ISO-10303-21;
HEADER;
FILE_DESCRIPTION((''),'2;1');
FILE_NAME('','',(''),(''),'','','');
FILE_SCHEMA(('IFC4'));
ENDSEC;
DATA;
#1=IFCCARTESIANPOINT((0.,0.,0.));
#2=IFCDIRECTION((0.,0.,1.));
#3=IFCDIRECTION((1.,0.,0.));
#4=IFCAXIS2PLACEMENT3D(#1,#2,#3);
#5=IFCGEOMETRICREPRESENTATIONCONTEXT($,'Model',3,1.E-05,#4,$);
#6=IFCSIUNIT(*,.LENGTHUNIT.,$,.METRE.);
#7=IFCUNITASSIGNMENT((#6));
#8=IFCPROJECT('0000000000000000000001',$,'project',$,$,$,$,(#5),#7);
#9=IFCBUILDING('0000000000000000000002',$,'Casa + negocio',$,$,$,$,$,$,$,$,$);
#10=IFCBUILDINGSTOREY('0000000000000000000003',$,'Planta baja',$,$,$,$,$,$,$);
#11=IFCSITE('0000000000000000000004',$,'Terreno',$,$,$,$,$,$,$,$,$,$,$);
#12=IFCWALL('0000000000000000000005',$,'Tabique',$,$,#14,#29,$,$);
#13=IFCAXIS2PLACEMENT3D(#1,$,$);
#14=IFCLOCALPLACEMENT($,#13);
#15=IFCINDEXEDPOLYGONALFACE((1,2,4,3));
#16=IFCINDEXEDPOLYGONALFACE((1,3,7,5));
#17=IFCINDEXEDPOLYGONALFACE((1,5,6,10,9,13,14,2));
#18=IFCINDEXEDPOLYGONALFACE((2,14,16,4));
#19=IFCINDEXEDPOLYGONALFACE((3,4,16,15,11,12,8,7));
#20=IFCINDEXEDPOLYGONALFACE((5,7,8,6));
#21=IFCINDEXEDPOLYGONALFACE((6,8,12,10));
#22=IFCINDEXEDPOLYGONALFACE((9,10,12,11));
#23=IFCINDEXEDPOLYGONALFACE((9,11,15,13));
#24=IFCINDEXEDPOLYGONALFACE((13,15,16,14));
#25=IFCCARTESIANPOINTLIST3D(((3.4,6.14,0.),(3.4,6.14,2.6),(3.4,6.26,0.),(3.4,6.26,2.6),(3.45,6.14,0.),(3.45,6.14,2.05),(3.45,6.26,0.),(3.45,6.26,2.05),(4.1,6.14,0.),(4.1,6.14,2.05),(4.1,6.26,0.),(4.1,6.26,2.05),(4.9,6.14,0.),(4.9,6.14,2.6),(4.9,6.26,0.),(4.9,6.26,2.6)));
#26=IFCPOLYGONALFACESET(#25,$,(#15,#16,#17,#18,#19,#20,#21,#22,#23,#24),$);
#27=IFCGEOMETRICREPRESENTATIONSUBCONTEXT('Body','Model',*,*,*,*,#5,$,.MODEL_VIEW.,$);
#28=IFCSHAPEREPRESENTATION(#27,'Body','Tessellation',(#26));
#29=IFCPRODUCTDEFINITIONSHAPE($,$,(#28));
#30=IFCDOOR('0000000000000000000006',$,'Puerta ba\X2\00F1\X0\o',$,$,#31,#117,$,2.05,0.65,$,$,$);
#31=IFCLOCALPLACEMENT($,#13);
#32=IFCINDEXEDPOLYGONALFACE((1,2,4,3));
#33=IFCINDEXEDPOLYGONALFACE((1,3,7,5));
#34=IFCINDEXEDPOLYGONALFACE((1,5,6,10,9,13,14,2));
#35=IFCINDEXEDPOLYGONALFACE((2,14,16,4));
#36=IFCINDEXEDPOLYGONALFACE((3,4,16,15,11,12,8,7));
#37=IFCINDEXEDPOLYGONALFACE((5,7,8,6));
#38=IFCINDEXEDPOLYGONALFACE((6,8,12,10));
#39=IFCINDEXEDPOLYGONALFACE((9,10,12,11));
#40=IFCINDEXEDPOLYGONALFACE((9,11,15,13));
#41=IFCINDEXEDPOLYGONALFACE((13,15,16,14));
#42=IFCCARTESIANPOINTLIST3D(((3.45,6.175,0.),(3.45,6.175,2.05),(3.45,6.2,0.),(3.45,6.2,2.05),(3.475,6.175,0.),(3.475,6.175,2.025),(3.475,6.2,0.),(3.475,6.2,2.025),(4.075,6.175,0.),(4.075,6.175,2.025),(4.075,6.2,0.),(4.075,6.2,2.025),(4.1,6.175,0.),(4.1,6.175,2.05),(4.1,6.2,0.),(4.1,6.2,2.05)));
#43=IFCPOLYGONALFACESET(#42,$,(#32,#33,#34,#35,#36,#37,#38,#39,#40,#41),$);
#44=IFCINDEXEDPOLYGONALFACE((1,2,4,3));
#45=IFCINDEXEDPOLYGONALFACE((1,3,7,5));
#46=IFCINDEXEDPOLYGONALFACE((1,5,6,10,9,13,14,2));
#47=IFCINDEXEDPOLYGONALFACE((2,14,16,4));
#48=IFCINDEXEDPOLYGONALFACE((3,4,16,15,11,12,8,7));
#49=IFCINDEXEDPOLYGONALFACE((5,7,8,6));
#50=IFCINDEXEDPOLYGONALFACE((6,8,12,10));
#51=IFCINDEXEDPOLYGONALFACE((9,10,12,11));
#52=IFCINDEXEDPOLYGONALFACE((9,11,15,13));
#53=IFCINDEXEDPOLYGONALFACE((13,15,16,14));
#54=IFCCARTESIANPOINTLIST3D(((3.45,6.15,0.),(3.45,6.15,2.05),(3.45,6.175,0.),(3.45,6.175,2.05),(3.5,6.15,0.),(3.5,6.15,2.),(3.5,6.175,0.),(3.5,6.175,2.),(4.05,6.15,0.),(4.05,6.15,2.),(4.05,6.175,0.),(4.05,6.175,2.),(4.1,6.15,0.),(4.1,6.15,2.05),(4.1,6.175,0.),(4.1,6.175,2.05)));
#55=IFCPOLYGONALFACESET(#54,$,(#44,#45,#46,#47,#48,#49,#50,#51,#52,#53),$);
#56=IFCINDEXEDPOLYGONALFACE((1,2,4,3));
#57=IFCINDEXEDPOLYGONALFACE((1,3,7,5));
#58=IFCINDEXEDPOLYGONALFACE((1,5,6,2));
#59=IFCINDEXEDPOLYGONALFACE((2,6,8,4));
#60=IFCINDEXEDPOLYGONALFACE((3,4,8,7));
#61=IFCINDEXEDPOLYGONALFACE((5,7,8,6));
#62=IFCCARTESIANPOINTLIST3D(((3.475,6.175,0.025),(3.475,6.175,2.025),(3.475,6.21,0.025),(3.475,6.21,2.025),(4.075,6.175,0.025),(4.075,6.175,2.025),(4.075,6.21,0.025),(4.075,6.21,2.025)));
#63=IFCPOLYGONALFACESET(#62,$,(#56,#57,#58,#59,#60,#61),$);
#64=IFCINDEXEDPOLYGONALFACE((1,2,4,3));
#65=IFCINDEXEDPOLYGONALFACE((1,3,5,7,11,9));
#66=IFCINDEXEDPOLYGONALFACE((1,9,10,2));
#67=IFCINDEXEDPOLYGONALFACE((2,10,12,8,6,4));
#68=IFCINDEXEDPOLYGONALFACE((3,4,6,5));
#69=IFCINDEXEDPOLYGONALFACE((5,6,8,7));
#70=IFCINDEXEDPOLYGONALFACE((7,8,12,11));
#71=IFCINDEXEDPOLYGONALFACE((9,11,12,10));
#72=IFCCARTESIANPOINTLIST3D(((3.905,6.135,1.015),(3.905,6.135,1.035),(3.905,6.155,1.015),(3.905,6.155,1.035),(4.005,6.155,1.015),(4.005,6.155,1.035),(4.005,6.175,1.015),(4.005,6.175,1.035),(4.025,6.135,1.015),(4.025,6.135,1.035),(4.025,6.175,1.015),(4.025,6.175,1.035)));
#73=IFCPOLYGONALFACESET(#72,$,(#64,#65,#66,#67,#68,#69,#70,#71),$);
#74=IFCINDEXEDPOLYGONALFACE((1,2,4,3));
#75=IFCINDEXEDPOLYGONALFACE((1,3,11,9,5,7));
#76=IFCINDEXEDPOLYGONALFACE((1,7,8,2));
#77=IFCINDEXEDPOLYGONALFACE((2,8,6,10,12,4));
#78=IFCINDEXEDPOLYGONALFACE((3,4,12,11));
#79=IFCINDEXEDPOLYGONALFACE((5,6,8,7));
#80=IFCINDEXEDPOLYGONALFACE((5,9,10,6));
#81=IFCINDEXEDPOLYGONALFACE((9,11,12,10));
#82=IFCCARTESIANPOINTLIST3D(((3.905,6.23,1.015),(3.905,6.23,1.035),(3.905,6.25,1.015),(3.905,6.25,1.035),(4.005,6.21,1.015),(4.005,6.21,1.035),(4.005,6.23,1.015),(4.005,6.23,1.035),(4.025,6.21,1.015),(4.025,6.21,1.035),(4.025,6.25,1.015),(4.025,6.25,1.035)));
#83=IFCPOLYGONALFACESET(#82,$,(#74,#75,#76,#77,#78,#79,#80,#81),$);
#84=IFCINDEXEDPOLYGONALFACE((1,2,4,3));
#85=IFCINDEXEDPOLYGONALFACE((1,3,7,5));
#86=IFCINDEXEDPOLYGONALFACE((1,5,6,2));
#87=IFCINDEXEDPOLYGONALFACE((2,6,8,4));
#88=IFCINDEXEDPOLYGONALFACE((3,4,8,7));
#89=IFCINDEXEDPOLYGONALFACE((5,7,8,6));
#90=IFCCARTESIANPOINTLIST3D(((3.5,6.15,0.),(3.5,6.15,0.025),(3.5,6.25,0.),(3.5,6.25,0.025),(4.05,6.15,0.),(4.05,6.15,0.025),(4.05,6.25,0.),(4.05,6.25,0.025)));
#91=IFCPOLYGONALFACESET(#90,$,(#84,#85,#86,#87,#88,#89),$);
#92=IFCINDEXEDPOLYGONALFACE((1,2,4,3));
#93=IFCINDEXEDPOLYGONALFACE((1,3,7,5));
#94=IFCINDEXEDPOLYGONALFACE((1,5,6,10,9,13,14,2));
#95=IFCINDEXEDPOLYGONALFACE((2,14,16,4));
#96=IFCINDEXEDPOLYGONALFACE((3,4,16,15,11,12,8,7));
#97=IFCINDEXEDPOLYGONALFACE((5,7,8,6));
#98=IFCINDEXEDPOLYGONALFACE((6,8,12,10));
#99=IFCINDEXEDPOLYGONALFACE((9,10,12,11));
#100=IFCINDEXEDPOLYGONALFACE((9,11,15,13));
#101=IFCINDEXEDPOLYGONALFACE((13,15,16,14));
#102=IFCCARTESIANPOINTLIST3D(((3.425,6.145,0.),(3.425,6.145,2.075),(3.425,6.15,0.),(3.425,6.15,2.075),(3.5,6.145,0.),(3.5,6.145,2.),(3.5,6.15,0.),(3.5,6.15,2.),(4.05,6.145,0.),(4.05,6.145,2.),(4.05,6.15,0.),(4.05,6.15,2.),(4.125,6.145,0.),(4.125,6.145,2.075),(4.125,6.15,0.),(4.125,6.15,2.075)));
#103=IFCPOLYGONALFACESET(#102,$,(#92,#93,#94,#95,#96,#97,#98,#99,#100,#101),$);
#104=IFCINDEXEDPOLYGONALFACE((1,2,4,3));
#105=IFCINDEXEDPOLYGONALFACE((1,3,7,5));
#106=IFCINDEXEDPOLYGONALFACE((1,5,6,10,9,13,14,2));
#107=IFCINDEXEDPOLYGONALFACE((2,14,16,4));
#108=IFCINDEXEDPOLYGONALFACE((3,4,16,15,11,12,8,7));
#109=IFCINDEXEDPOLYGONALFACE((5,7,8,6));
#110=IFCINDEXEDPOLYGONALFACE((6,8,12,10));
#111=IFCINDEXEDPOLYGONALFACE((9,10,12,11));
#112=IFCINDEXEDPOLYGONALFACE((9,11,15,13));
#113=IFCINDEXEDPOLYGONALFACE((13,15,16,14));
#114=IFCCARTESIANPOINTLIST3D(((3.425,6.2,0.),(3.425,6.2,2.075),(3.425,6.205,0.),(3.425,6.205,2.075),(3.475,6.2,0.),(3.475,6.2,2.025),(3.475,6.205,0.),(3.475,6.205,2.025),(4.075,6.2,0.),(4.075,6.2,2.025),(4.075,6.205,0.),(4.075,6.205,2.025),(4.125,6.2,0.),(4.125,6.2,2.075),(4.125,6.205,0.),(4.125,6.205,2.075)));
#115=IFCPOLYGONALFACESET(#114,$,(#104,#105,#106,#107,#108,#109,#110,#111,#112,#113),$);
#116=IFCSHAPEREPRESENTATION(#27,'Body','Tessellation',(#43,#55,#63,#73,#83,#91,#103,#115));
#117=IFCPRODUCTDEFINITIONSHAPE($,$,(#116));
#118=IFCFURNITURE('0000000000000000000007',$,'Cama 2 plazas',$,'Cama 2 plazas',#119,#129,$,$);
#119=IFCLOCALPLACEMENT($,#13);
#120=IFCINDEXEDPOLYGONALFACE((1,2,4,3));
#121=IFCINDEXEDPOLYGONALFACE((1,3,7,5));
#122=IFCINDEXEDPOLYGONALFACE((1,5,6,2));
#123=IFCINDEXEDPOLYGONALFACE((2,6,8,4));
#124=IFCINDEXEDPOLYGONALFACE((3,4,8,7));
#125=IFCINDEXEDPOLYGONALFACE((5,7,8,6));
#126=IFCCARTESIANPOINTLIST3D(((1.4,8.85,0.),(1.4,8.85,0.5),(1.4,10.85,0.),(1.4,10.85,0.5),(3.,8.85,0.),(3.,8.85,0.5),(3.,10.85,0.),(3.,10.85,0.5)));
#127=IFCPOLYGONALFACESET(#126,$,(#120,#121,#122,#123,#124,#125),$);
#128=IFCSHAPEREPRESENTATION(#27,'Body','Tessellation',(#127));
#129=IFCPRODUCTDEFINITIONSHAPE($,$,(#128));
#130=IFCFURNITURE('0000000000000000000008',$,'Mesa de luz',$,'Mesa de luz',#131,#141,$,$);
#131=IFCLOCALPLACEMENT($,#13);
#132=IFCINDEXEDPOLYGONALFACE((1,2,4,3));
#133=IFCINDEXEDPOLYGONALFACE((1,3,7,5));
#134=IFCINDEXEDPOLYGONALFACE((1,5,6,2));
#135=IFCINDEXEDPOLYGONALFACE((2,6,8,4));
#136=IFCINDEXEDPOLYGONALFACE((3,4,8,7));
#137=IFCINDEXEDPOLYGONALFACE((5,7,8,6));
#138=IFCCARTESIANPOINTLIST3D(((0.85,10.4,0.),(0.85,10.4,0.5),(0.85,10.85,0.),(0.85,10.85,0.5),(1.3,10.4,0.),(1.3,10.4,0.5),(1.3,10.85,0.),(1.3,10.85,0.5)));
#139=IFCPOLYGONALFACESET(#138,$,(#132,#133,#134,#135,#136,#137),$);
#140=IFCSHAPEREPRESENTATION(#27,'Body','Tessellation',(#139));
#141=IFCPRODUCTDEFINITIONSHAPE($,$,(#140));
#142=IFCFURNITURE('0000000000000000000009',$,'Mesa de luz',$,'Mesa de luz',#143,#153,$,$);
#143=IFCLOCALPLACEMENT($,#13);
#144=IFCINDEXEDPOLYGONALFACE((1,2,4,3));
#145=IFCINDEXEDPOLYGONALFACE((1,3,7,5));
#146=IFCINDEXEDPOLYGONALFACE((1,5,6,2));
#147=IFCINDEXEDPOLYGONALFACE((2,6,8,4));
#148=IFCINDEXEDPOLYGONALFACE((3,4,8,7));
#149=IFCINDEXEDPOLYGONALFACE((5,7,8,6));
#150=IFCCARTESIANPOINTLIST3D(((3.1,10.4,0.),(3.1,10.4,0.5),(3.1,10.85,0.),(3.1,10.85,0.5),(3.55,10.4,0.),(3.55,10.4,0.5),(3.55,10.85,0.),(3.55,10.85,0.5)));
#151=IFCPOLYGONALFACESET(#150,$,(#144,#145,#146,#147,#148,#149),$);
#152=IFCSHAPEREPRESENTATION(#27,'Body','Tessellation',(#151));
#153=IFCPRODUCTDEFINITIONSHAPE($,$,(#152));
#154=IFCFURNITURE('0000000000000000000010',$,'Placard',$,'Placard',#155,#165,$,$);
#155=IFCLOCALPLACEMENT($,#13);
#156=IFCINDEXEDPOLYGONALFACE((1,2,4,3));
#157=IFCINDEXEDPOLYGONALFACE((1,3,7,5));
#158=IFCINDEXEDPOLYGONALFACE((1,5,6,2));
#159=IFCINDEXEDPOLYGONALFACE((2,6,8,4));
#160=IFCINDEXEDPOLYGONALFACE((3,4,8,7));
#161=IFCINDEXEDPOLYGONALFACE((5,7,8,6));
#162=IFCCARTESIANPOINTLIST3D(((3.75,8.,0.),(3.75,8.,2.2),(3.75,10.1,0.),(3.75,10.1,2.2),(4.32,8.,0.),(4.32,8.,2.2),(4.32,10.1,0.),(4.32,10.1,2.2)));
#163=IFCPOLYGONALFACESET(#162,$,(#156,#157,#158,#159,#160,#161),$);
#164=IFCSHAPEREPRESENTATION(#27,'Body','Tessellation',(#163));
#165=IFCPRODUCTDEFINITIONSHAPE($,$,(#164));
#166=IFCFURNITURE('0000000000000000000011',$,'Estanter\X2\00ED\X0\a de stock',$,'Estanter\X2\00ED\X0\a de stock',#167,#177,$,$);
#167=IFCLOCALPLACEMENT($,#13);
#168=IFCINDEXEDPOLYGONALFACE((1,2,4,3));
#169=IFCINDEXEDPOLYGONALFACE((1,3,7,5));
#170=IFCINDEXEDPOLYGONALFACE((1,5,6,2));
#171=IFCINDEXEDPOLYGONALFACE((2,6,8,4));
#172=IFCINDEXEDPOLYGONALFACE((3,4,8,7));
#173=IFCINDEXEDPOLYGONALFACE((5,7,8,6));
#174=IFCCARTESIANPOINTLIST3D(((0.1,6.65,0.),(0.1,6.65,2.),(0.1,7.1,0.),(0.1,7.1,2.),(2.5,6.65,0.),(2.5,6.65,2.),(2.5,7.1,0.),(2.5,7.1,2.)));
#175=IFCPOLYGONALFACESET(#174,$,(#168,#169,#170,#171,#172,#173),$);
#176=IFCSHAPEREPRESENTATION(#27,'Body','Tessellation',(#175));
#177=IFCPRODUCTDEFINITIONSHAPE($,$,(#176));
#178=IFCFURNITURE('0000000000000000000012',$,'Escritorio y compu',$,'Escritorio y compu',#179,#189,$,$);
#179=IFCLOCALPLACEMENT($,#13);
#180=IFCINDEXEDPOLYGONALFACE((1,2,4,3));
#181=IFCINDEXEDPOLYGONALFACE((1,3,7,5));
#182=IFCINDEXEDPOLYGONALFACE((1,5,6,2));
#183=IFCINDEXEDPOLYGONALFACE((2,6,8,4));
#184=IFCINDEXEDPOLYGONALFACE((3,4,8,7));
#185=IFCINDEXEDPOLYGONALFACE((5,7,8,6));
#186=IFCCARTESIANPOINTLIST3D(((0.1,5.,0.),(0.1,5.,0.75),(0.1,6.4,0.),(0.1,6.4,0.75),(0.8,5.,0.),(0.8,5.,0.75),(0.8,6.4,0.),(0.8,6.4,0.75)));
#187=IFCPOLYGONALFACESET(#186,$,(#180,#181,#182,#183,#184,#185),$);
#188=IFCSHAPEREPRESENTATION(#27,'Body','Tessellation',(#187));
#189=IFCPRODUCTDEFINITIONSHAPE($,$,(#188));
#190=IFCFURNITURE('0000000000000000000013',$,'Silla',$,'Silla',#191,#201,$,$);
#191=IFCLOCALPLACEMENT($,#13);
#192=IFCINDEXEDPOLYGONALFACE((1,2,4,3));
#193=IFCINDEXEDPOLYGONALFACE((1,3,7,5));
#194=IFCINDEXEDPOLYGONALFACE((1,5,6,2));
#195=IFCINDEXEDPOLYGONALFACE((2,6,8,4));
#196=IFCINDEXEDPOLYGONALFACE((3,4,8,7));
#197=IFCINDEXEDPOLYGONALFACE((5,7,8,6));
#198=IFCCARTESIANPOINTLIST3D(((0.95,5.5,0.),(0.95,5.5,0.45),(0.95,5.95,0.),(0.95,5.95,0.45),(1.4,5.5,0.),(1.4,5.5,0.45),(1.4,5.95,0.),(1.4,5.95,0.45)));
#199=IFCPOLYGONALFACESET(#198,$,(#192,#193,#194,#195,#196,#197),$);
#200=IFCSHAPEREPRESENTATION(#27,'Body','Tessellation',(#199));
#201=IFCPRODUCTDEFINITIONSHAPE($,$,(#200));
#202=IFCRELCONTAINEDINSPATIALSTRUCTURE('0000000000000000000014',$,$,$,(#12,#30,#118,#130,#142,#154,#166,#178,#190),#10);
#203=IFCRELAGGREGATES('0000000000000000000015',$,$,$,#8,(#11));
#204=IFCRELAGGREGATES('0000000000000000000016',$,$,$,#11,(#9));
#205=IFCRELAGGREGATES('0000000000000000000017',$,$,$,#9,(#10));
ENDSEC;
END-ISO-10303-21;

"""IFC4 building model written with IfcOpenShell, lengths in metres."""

from ifc_helpers import new_model, si_unit, frame, origin_with_axes, place, context, subcontext, project, spatial, line, indexed_curve, outline, extrude, element, fill, save


model = new_model("IFC4")

# Units and contexts
model_context = context("Model", 3, precision=1e-05, world=origin_with_axes())
body_context = subcontext(model_context, "Body", "Model", "MODEL_VIEW")
ifc_project = project(units=[si_unit("LENGTHUNIT", "METRE")], contexts=[model_context])

# Site, building, storey
site = spatial("IfcSite", under=ifc_project, Name="Terreno")
building = spatial("IfcBuilding", under=site, Name="Casa + negocio")
storey = spatial("IfcBuildingStorey", under=building, Name="Planta baja")

# Wall, opening, door
wall_1_placement = place(None, frame((3.4, 6.2, 0.0), z_axis=(0.0, 0.0, 1.0), x_axis=(1.0, 0.0, 0.0)))
wall_1 = element("IfcWall", 1, at=wall_1_placement, inside=storey, Name="Tabique", context=body_context, shape_type="SweptSolid", body=[
    extrude(outline(indexed_curve([(0.0, 0.0), (0.0, 0.12), (1.5, 0.12), (1.5, 0.0), (0.0, 0.0)], self_intersect=False)), frame((0.0, -0.06, 0.0), z_axis=(0.0, 0.0, 1.0), x_axis=(1.0, 0.0, 0.0)), (0.0, 0.0, 1.0), 2.6),
])
opening_1_placement = place(wall_1_placement, frame((0.05, 0.0, 0.0), z_axis=(0.0, 0.0, 1.0), x_axis=(1.0, 0.0, 0.0)))
opening_1 = element("IfcOpeningElement", 2, at=opening_1_placement, cuts=wall_1, context=body_context, shape_type="SweptSolid", body=[
    extrude(outline(indexed_curve([(0.0, 0.0), (0.0, 0.22), (0.65, 0.22), (0.65, 0.0), (0.0, 0.0)], self_intersect=False)), frame((0.0, -0.11, 0.0), z_axis=(0.0, 0.0, 1.0), x_axis=(1.0, 0.0, 0.0)), (0.0, 0.0, 1.0), 2.05),
])
door_1_placement = place(opening_1_placement, frame((0.0, -0.05, 0.0), z_axis=(0.0, 0.0, 1.0), x_axis=(1.0, 0.0, 0.0)))
door_1 = element("IfcDoor", 3, at=door_1_placement, inside=storey, Name="Puerta baño", OverallHeight=2.05, OverallWidth=0.65, context=body_context, shape_type="SweptSolid", body=[
    extrude(outline(indexed_curve([(0.0, 0.0), (0.0, 2.05), (0.65, 2.05), (0.65, 0.0), (0.625, 0.0), (0.625, 2.025), (0.025, 2.025), (0.025, 0.0)], segments=[line(1, 2, 3, 4, 5, 6, 7, 8, 1)])), frame((0.0, 0.025, 0.0), z_axis=(0.0, -1.0, 0.0), x_axis=(1.0, 0.0, 0.0)), (0.0, 0.0, -1.0), 0.025),
    extrude(outline(indexed_curve([(0.0, 0.0), (0.0, 2.05), (0.65, 2.05), (0.65, 0.0), (0.6, 0.0), (0.6, 2.0), (0.05, 2.0), (0.05, 0.0)], segments=[line(1, 2, 3, 4, 5, 6, 7, 8, 1)])), frame((0.0, 0.0, 0.0), z_axis=(0.0, -1.0, 0.0), x_axis=(1.0, 0.0, 0.0)), (0.0, 0.0, -1.0), 0.025),
    extrude(outline(indexed_curve([(0.0, 0.0), (0.6, 0.0), (0.6, 0.035), (0.0, 0.035)], segments=[line(1, 2, 3, 4, 1)])), frame((0.025, 0.025, 0.025), z_axis=(0.0, 0.0, 1.0), x_axis=(1.0, 0.0, 0.0)), (0.0, 0.0, 1.0), 2.0),
    extrude(outline(indexed_curve([(0.0, 0.0), (0.0, -0.04), (-0.12, -0.04), (-0.12, -0.02), (-0.02, -0.02), (-0.02, 0.0)], segments=[line(1, 2, 3, 4, 5, 6, 1)])), frame((0.575, 0.025, 1.015), z_axis=(0.0, 0.0, 1.0), x_axis=(1.0, 0.0, 0.0)), (0.0, 0.0, 1.0), 0.02),
    extrude(outline(indexed_curve([(0.0, 0.0), (0.0, 0.04), (-0.12, 0.04), (-0.12, 0.02), (-0.02, 0.02), (-0.02, 0.0)], segments=[line(1, 2, 3, 4, 5, 6, 1)])), frame((0.575, 0.06, 1.015), z_axis=(0.0, 0.0, 1.0), x_axis=(1.0, 0.0, 0.0)), (0.0, 0.0, 1.0), 0.02),
    extrude(outline(indexed_curve([(0.0, 0.0), (0.55, 0.0), (0.55, 0.1), (0.0, 0.1)], segments=[line(1, 2, 3, 4, 1)])), frame((0.05, 0.0, 0.0), z_axis=(0.0, 0.0, 1.0), x_axis=(1.0, 0.0, 0.0)), (0.0, 0.0, 1.0), 0.025),
    extrude(outline(indexed_curve([(0.0, 0.0), (0.0, 2.075), (0.7, 2.075), (0.7, 0.0), (0.625, 0.0), (0.625, 2.0), (0.075, 2.0), (0.075, 0.0)], segments=[line(1, 2, 3, 4, 5, 6, 7, 8, 1)])), frame((-0.025, -0.005, 0.0), z_axis=(0.0, -1.0, 0.0), x_axis=(1.0, 0.0, 0.0)), (0.0, 0.0, -1.0), 0.005),
    extrude(outline(indexed_curve([(0.0, 0.0), (0.0, 2.075), (0.7, 2.075), (0.7, 0.0), (0.65, 0.0), (0.65, 2.025), (0.05, 2.025), (0.05, 0.0)], segments=[line(1, 2, 3, 4, 5, 6, 7, 8, 1)])), frame((-0.025, 0.05, 0.0), z_axis=(0.0, -1.0, 0.0), x_axis=(1.0, 0.0, 0.0)), (0.0, 0.0, -1.0), 0.005),
])
fill(opening_1, door_1)

# Furniture
furniture_1_placement = place(None, frame((1.4, 8.85, 0.0), z_axis=(0.0, 0.0, 1.0), x_axis=(1.0, 0.0, 0.0)))
element("IfcFurniture", 4, at=furniture_1_placement, inside=storey, Name="Cama 2 plazas", ObjectType="Cama 2 plazas", context=body_context, shape_type="SweptSolid", body=[
    extrude(outline(indexed_curve([(0.0, 0.0), (1.6, 0.0), (1.6, 2.0), (0.0, 2.0)], segments=[line(1, 2, 3, 4, 1)])), origin_with_axes(), (0.0, 0.0, 1.0), 0.5),
])
furniture_2_placement = place(None, frame((0.85, 10.4, 0.0), z_axis=(0.0, 0.0, 1.0), x_axis=(1.0, 0.0, 0.0)))
element("IfcFurniture", 5, at=furniture_2_placement, inside=storey, Name="Mesa de luz", ObjectType="Mesa de luz", context=body_context, shape_type="SweptSolid", body=[
    extrude(outline(indexed_curve([(0.0, 0.0), (0.45, 0.0), (0.45, 0.45), (0.0, 0.45)], segments=[line(1, 2, 3, 4, 1)])), origin_with_axes(), (0.0, 0.0, 1.0), 0.5),
])
furniture_3_placement = place(None, frame((3.1, 10.4, 0.0), z_axis=(0.0, 0.0, 1.0), x_axis=(1.0, 0.0, 0.0)))
element("IfcFurniture", 6, at=furniture_3_placement, inside=storey, Name="Mesa de luz", ObjectType="Mesa de luz", context=body_context, shape_type="SweptSolid", body=[
    extrude(outline(indexed_curve([(0.0, 0.0), (0.45, 0.0), (0.45, 0.45), (0.0, 0.45)], segments=[line(1, 2, 3, 4, 1)])), origin_with_axes(), (0.0, 0.0, 1.0), 0.5),
])
furniture_4_placement = place(None, frame((3.75, 8.0, 0.0), z_axis=(0.0, 0.0, 1.0), x_axis=(1.0, 0.0, 0.0)))
element("IfcFurniture", 7, at=furniture_4_placement, inside=storey, Name="Placard", ObjectType="Placard", context=body_context, shape_type="SweptSolid", body=[
    extrude(outline(indexed_curve([(0.0, 0.0), (0.57, 0.0), (0.57, 2.1), (0.0, 2.1)], segments=[line(1, 2, 3, 4, 1)])), origin_with_axes(), (0.0, 0.0, 1.0), 2.2),
])
furniture_5_placement = place(None, frame((0.1, 6.65, 0.0), z_axis=(0.0, 0.0, 1.0), x_axis=(1.0, 0.0, 0.0)))
element("IfcFurniture", 8, at=furniture_5_placement, inside=storey, Name="Estantería de stock", ObjectType="Estantería de stock", context=body_context, shape_type="SweptSolid", body=[
    extrude(outline(indexed_curve([(0.0, 0.0), (2.4, 0.0), (2.4, 0.45), (0.0, 0.45)], segments=[line(1, 2, 3, 4, 1)])), origin_with_axes(), (0.0, 0.0, 1.0), 2.0),
])
furniture_6_placement = place(None, frame((0.1, 5.0, 0.0), z_axis=(0.0, 0.0, 1.0), x_axis=(1.0, 0.0, 0.0)))
element("IfcFurniture", 9, at=furniture_6_placement, inside=storey, Name="Escritorio y compu", ObjectType="Escritorio y compu", context=body_context, shape_type="SweptSolid", body=[
    extrude(outline(indexed_curve([(0.0, 0.0), (0.7, 0.0), (0.7, 1.4), (0.0, 1.4)], segments=[line(1, 2, 3, 4, 1)])), origin_with_axes(), (0.0, 0.0, 1.0), 0.75),
])
furniture_7_placement = place(None, frame((0.95, 5.5, 0.0), z_axis=(0.0, 0.0, 1.0), x_axis=(1.0, 0.0, 0.0)))
element("IfcFurniture", 10, at=furniture_7_placement, inside=storey, Name="Silla", ObjectType="Silla", context=body_context, shape_type="SweptSolid", body=[
    extrude(outline(indexed_curve([(0.0, 0.0), (0.45, 0.0), (0.45, 0.45), (0.0, 0.45)], segments=[line(1, 2, 3, 4, 1)])), origin_with_axes(), (0.0, 0.0, 1.0), 0.45),
])

save(model, "model.ifc")
